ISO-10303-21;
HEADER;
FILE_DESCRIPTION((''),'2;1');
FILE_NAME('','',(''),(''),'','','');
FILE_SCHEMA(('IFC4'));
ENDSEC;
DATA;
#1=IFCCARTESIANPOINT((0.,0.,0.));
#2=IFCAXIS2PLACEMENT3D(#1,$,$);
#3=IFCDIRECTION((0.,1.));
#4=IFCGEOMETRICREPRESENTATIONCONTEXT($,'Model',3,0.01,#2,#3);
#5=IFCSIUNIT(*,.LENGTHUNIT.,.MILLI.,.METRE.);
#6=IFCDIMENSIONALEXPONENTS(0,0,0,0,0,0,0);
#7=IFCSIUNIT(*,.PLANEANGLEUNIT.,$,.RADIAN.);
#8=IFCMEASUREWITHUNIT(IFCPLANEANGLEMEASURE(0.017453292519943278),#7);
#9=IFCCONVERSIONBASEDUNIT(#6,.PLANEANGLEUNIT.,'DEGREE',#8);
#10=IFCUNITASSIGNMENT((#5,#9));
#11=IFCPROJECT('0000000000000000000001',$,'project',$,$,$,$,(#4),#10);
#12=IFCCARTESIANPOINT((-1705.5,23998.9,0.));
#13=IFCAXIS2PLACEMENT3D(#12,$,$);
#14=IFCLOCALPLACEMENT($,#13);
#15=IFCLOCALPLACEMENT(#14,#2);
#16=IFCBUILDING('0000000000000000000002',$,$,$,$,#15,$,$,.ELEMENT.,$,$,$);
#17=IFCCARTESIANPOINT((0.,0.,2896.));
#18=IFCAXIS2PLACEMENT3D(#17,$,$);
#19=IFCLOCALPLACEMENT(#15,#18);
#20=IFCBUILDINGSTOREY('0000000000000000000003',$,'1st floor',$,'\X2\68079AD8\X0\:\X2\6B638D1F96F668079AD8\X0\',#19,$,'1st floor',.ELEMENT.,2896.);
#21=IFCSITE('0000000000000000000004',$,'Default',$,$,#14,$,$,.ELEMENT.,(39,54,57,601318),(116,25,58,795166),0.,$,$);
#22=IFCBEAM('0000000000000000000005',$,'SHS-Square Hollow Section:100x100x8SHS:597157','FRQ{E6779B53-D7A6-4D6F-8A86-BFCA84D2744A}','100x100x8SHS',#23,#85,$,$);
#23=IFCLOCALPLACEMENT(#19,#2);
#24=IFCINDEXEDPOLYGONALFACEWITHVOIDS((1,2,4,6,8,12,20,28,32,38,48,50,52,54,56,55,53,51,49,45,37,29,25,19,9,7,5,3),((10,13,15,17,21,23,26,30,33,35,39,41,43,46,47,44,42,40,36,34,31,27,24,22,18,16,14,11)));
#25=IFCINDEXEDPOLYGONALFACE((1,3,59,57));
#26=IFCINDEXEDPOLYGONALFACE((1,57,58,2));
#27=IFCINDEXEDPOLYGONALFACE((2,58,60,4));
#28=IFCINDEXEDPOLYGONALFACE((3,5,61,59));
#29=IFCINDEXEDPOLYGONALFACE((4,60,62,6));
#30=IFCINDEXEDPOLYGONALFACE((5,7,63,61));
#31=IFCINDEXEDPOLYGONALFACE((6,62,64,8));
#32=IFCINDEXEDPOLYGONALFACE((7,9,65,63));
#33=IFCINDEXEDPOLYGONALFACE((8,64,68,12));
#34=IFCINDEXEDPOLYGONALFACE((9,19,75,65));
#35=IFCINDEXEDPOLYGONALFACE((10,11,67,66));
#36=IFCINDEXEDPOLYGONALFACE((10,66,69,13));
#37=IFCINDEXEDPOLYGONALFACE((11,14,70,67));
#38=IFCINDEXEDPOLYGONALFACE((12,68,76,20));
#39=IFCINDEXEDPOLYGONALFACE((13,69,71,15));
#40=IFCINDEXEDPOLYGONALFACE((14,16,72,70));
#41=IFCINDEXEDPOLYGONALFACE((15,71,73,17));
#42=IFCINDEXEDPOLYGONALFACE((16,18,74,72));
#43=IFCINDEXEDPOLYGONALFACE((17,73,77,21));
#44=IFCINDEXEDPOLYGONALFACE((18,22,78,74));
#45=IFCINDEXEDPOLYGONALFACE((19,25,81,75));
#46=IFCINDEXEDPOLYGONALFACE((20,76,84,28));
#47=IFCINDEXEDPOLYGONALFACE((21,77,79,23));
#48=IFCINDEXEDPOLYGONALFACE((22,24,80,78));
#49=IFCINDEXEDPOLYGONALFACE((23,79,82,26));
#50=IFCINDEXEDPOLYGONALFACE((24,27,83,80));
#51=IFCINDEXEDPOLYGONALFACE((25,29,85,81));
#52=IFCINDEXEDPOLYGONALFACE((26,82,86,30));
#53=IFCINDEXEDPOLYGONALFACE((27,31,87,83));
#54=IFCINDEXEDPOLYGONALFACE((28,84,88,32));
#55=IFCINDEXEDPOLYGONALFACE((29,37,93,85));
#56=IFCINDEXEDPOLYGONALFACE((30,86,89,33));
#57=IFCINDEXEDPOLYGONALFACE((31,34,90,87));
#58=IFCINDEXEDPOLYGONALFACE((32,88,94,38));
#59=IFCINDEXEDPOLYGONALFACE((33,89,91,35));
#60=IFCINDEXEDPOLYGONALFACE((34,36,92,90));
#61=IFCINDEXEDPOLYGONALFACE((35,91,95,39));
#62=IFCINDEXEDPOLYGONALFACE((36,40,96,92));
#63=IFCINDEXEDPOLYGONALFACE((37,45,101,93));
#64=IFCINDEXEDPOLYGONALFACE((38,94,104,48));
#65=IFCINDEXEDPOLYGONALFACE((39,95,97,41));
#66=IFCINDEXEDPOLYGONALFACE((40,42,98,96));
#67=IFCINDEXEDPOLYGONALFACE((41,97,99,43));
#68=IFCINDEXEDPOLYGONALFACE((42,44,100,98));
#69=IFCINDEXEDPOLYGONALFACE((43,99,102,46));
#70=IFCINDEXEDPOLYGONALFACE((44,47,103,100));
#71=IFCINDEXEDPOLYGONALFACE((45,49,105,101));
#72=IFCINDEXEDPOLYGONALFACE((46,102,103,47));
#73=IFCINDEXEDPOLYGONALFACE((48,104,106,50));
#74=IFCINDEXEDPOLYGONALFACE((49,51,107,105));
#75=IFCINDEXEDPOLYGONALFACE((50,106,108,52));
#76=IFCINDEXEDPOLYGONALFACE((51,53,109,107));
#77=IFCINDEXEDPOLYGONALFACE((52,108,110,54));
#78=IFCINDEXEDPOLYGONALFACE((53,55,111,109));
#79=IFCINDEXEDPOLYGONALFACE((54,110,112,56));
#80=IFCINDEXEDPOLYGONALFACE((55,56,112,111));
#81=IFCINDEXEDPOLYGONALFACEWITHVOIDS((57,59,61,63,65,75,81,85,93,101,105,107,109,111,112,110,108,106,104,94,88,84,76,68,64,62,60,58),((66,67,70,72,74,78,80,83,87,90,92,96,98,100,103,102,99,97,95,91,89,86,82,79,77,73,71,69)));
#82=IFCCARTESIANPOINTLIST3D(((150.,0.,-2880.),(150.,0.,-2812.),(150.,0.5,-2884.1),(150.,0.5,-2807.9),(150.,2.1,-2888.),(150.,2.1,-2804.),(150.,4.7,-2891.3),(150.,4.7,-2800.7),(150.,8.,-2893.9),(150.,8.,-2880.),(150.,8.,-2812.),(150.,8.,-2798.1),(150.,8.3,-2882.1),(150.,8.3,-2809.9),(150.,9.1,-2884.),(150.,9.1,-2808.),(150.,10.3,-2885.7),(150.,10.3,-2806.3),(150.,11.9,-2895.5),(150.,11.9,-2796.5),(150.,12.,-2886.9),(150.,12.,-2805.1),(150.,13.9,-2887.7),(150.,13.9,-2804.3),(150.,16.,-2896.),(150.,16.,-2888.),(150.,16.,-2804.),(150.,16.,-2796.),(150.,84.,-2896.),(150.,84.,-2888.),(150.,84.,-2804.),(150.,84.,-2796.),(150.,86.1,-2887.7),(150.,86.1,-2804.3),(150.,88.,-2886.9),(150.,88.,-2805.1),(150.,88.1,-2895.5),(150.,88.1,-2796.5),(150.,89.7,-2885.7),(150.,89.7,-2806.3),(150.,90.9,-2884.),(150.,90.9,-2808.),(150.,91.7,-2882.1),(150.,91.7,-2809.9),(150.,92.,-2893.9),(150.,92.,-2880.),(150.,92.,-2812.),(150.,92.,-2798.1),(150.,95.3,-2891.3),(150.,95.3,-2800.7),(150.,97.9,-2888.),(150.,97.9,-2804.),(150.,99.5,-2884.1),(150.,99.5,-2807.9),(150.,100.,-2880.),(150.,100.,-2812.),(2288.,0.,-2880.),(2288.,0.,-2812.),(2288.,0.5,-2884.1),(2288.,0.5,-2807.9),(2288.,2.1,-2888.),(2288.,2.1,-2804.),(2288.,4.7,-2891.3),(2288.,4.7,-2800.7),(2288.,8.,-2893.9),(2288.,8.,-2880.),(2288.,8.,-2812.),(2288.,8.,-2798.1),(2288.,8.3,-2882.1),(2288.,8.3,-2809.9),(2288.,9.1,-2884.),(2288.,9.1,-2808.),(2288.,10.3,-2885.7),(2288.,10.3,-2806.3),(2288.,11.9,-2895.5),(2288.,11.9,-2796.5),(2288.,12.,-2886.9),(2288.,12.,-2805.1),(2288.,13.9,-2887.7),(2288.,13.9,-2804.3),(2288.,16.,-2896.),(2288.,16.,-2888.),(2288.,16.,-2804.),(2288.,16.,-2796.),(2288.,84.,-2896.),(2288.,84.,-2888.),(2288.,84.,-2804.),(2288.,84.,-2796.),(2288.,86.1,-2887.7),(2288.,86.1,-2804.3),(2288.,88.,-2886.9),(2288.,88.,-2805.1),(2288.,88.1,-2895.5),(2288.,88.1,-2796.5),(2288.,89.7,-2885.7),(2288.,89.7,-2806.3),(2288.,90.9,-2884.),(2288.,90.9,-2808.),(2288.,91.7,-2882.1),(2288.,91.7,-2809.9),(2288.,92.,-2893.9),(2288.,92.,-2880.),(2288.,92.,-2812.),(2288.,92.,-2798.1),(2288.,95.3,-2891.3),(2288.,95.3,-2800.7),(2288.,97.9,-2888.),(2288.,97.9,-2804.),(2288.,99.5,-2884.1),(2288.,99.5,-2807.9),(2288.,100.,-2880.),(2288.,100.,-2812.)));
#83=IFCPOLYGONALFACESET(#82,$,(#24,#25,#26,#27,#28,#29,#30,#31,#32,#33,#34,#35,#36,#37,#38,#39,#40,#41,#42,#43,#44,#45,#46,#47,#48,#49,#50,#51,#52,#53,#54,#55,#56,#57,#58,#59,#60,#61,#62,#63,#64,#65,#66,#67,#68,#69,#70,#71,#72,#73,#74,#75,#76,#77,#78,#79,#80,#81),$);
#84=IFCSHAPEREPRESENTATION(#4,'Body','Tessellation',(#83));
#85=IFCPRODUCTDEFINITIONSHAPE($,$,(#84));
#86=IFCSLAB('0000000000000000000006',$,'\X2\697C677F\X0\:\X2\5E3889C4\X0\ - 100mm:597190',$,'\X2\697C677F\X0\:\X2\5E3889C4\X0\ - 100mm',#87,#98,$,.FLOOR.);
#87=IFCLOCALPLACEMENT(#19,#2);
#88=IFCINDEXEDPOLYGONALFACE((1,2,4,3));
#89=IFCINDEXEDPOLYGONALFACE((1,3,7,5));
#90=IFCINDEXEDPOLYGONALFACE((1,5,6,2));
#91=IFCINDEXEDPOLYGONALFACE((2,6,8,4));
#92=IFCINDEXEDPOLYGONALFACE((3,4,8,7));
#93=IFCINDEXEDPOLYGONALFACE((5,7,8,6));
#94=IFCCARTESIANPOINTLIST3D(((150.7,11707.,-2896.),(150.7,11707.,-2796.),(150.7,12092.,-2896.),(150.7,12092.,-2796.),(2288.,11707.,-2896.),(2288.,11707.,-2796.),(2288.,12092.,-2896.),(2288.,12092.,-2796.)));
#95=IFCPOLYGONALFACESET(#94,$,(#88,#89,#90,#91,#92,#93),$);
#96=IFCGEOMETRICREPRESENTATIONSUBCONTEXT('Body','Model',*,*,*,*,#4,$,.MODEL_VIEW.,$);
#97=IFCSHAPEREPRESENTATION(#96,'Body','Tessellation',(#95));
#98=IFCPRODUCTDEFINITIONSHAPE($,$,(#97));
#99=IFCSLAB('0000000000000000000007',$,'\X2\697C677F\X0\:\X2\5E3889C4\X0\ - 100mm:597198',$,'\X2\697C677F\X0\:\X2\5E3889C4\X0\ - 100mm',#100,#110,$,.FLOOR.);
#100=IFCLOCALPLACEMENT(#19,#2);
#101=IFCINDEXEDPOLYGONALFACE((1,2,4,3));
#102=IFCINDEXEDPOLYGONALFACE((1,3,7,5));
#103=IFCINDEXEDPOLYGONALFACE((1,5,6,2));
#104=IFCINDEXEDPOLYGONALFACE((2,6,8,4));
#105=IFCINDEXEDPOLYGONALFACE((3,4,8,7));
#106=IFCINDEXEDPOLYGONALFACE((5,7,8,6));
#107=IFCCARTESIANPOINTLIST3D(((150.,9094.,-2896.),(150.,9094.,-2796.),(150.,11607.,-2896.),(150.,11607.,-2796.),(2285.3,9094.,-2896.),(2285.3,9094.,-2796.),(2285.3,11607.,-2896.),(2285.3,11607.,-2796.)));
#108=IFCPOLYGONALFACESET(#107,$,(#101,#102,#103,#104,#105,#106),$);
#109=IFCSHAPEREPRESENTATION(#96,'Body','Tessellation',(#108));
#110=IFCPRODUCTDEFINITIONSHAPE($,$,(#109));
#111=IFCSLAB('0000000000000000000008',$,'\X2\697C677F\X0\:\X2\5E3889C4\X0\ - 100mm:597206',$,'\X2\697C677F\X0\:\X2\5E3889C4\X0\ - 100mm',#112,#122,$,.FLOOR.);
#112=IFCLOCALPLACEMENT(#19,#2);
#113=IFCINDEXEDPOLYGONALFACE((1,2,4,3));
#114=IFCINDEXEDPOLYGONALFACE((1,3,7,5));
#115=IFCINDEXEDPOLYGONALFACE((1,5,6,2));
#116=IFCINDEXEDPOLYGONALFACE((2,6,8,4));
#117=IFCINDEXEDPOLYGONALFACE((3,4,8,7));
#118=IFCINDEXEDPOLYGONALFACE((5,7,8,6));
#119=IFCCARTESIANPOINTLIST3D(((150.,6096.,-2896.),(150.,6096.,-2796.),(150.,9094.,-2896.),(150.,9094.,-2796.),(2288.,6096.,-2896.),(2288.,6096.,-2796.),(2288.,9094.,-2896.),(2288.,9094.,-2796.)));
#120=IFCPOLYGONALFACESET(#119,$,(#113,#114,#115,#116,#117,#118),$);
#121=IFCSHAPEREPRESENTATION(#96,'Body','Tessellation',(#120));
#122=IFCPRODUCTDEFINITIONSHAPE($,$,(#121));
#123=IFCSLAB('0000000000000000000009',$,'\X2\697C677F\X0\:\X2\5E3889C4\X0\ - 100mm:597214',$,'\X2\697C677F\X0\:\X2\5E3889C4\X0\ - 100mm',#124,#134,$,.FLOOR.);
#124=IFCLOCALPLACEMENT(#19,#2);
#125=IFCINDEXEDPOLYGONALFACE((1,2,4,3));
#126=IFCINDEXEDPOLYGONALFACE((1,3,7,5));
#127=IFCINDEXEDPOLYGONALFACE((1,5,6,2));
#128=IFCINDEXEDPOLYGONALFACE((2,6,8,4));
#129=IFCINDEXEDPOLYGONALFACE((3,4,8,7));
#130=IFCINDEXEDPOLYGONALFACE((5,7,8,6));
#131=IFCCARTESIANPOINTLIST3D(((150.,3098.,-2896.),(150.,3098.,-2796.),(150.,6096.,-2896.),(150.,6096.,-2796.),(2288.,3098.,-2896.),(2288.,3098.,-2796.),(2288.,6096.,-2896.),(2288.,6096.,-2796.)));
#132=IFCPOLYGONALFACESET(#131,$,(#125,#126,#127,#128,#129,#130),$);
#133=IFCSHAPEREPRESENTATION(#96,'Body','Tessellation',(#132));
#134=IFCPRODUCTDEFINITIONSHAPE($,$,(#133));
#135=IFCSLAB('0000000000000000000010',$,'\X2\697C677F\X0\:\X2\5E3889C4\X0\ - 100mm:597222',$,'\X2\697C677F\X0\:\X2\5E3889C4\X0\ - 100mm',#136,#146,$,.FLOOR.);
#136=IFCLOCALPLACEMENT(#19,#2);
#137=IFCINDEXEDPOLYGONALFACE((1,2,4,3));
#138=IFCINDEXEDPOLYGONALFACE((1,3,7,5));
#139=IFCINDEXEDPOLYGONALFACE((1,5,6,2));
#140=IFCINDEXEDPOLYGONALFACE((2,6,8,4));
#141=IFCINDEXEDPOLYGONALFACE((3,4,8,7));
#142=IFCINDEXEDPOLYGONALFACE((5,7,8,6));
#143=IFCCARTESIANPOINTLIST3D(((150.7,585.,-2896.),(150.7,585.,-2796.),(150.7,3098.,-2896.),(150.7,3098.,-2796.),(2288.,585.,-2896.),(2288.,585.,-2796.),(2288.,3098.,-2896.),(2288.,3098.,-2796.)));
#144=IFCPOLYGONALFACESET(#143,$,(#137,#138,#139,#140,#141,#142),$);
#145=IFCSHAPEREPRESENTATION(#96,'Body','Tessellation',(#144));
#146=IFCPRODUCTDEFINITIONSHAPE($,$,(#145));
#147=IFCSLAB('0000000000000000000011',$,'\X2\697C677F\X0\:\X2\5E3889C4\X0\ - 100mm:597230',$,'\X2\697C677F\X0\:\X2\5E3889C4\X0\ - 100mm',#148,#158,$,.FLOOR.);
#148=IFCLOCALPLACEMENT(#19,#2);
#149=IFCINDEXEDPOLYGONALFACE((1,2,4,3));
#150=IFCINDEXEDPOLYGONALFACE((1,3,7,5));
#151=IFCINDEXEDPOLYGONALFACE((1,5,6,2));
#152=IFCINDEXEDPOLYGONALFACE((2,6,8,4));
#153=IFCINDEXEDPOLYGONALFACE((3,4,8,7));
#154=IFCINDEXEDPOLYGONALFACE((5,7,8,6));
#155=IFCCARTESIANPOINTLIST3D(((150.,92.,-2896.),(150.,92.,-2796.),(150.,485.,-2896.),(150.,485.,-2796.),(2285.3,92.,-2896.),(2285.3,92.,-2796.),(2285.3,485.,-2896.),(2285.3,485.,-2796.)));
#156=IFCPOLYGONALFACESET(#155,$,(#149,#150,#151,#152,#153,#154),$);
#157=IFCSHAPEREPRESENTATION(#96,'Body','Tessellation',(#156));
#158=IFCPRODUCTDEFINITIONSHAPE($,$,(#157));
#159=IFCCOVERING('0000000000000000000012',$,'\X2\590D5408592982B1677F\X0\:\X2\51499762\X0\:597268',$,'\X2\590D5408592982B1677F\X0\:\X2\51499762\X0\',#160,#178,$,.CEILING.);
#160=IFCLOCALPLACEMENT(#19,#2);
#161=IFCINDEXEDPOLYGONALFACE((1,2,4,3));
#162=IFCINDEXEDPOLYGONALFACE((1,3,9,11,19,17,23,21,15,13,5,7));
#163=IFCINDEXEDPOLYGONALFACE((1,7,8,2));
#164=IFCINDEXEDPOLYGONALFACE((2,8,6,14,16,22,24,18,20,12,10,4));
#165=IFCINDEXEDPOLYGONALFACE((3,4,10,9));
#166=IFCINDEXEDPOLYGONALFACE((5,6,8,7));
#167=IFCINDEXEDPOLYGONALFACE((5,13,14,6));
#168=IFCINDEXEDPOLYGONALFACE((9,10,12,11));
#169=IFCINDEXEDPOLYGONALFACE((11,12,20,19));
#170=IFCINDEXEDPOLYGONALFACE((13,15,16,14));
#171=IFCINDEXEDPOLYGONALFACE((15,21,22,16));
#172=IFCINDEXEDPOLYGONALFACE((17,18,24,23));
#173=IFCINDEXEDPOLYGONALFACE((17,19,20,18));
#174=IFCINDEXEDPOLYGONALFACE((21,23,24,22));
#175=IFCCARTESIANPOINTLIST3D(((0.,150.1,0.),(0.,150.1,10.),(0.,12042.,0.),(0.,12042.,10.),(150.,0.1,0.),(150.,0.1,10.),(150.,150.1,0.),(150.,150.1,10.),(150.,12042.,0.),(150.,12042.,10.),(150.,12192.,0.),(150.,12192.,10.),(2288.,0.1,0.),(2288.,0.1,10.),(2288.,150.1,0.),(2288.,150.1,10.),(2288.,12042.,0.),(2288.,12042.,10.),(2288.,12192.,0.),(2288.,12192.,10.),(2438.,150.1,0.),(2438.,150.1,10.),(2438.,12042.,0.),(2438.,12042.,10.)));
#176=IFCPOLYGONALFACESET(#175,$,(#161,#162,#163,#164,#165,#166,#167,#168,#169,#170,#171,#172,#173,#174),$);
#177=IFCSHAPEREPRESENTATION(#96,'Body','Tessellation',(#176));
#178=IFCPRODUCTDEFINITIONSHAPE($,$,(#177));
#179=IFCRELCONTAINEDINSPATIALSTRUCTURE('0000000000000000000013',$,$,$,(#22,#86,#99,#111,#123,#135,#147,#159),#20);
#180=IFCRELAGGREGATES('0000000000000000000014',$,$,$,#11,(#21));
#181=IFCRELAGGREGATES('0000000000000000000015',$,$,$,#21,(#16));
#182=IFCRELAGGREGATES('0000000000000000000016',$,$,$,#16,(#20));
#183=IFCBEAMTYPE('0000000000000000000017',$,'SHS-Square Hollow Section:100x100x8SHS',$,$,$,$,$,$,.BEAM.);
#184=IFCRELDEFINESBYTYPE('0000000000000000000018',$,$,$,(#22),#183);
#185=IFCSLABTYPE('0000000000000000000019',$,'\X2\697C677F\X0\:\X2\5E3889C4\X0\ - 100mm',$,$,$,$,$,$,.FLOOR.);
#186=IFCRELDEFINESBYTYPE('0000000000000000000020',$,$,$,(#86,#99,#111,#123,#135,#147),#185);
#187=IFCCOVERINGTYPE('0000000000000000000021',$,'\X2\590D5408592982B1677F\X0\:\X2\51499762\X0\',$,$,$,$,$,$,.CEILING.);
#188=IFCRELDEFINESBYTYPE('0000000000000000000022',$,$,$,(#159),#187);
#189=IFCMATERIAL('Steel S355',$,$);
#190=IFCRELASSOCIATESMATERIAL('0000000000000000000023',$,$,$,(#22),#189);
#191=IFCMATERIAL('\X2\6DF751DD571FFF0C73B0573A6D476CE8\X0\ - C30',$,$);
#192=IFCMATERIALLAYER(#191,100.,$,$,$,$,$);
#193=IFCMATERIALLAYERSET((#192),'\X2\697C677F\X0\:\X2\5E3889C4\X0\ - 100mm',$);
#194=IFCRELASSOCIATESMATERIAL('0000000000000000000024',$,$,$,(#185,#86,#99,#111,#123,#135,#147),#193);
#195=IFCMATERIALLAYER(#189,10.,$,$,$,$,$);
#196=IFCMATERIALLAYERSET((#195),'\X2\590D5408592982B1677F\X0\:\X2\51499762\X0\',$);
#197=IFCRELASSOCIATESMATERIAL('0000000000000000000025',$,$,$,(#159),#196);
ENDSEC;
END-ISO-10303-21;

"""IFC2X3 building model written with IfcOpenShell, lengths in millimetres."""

from ifc_helpers import new_model, entity, si_unit, converted_unit, direction, frame, frame_2d, origin, origin_2d, origin_2d_with_axis, place, context, subcontext, project, spatial, polyline, rectangle, hollow_rectangle, outline, extrude, clip, halfspace, material, layer, layer_set, layer_usage, type_object, element, save


model = new_model("IFC2X3")

# Units and contexts
model_context = context("Model", 3, precision=0.01, world=origin(), true_north=direction((0.0, 1.0)))
body_context = subcontext(model_context, "Body", "Model", "MODEL_VIEW")
ifc_project = project(units=[si_unit("LENGTHUNIT", "METRE", prefix="MILLI"), converted_unit("PLANEANGLEUNIT", "DEGREE", entity("IfcPlaneAngleMeasure", 0.017453292519943278), si_unit("PLANEANGLEUNIT", "RADIAN"), dimensions=[0, 0, 0, 0, 0, 0, 0])], contexts=[model_context])

# Site, building, storey
site_placement = place(None, frame((-1705.5, 23998.9, 0.0)))
site = spatial("IfcSite", under=ifc_project, at=site_placement, Name="Default", CompositionType="ELEMENT", RefLatitude=(39, 54, 57, 601318), RefLongitude=(116, 25, 58, 795166), RefElevation=0.0)
building_placement = place(site_placement, origin())
building = spatial("IfcBuilding", under=site, at=building_placement, CompositionType="ELEMENT")
storey_placement = place(building_placement, frame((0.0, 0.0, 2896.0)))
storey = spatial("IfcBuildingStorey", under=building, at=storey_placement, Name="1st floor", ObjectType="标高:正负零标高", LongName="1st floor", CompositionType="ELEMENT", Elevation=2896.0)

# Shared definitions
ifc_material_1 = material(Name="Steel S355")

# Beam
beam_type_1 = type_object("IfcBeamType", Name="SHS-Square Hollow Section:100x100x8SHS", PredefinedType="BEAM")
beam_1_placement = place(storey_placement, frame((-57.7, 50.0, -2846.0), z_axis=(-1.0, 0.0, 0.0), x_axis=(0.0, -1.0, 0.0)))
element("IfcBeam", 1, at=beam_1_placement, inside=storey, type_object=beam_type_1, material=ifc_material_1, Name="SHS-Square Hollow Section:100x100x8SHS:597157", Description="FRQ{E6779B53-D7A6-4D6F-8A86-BFCA84D2744A}", ObjectType="100x100x8SHS", context=model_context, shape_type="Clipping", body=[
    clip(clip(extrude(hollow_rectangle(XDim=100.0, YDim=100.0, WallThickness=8.0, InnerFilletRadius=8.0, OuterFilletRadius=16.0, at=origin_2d()), origin(), (0.0, 0.0, -1.0), 2551.4), halfspace(frame((50.0, -50.0, -2345.7), z_axis=(0.0, 0.0, 1.0), x_axis=(1.0, 0.0, 0.0)), True)), halfspace(frame((50.0, -50.0, -207.7), z_axis=(0.0, 0.0, -1.0), x_axis=(-1.0, 0.0, 0.0)), True)),
])

# Slabs
ifc_material_2 = material(Name="混凝土，现场浇注 - C30")
ifc_layer_1 = layer(ifc_material_2, 100.0)
ifc_layer_set_1 = layer_set([ifc_layer_1], Name="楼板:常规 - 100mm")
ifc_layer_usage_1 = layer_usage(ifc_layer_set_1, "AXIS3", "POSITIVE", 0.0)
slab_type = type_object("IfcSlabType", Name="楼板:常规 - 100mm", PredefinedType="FLOOR", material=ifc_layer_set_1)
slab_1_placement = place(storey_placement, origin())
element("IfcSlab", 2, at=slab_1_placement, inside=storey, type_object=slab_type, material=ifc_layer_usage_1, Name="楼板:常规 - 100mm:597190", ObjectType="楼板:常规 - 100mm", PredefinedType="FLOOR", context=body_context, shape_type="SweptSolid", body=[
    extrude(rectangle(XDim=385.0, YDim=2137.3, at=origin_2d_with_axis()), frame((1219.3, 11899.5, -2796.0), z_axis=(0.0, 0.0, -1.0), x_axis=(0.0, 1.0, 0.0)), (0.0, 0.0, 1.0), 100.0),
])
ifc_layer_usage_2 = layer_usage(ifc_layer_set_1, "AXIS3", "POSITIVE", 0.0)
slab_2_placement = place(storey_placement, origin())
element("IfcSlab", 3, at=slab_2_placement, inside=storey, type_object=slab_type, material=ifc_layer_usage_2, Name="楼板:常规 - 100mm:597198", ObjectType="楼板:常规 - 100mm", PredefinedType="FLOOR", context=body_context, shape_type="SweptSolid", body=[
    extrude(rectangle(XDim=2513.0, YDim=2135.3, at=frame_2d((0.0, 0.0), x_axis=(1.0, 0.0))), frame((1217.6, 10350.5, -2796.0), z_axis=(0.0, 0.0, -1.0), x_axis=(0.0, 1.0, 0.0)), (0.0, 0.0, 1.0), 100.0),
])
ifc_layer_usage_3 = layer_usage(ifc_layer_set_1, "AXIS3", "POSITIVE", 0.0)
slab_3_placement = place(storey_placement, origin())
element("IfcSlab", 4, at=slab_3_placement, inside=storey, type_object=slab_type, material=ifc_layer_usage_3, Name="楼板:常规 - 100mm:597206", ObjectType="楼板:常规 - 100mm", PredefinedType="FLOOR", context=body_context, shape_type="SweptSolid", body=[
    extrude(rectangle(XDim=2998.0, YDim=2138.0, at=origin_2d_with_axis()), frame((1219.0, 7595.0, -2796.0), z_axis=(0.0, 0.0, -1.0), x_axis=(0.0, 1.0, 0.0)), (0.0, 0.0, 1.0), 100.0),
])
ifc_layer_usage_4 = layer_usage(ifc_layer_set_1, "AXIS3", "POSITIVE", 0.0)
slab_4_placement = place(storey_placement, origin())
element("IfcSlab", 5, at=slab_4_placement, inside=storey, type_object=slab_type, material=ifc_layer_usage_4, Name="楼板:常规 - 100mm:597214", ObjectType="楼板:常规 - 100mm", PredefinedType="FLOOR", context=body_context, shape_type="SweptSolid", body=[
    extrude(rectangle(XDim=2998.0, YDim=2138.0, at=frame_2d((0.0, 0.0), x_axis=(1.0, 0.0))), frame((1219.0, 4597.0, -2796.0), z_axis=(0.0, 0.0, -1.0), x_axis=(0.0, 1.0, 0.0)), (0.0, 0.0, 1.0), 100.0),
])
ifc_layer_usage_5 = layer_usage(ifc_layer_set_1, "AXIS3", "POSITIVE", 0.0)
slab_5_placement = place(storey_placement, origin())
element("IfcSlab", 6, at=slab_5_placement, inside=storey, type_object=slab_type, material=ifc_layer_usage_5, Name="楼板:常规 - 100mm:597222", ObjectType="楼板:常规 - 100mm", PredefinedType="FLOOR", context=body_context, shape_type="SweptSolid", body=[
    extrude(rectangle(XDim=2513.0, YDim=2137.3, at=origin_2d_with_axis()), frame((1219.3, 1841.5, -2796.0), z_axis=(0.0, 0.0, -1.0), x_axis=(0.0, 1.0, 0.0)), (0.0, 0.0, 1.0), 100.0),
])
ifc_layer_usage_6 = layer_usage(ifc_layer_set_1, "AXIS3", "POSITIVE", 0.0)
slab_6_placement = place(storey_placement, origin())
element("IfcSlab", 7, at=slab_6_placement, inside=storey, type_object=slab_type, material=ifc_layer_usage_6, Name="楼板:常规 - 100mm:597230", ObjectType="楼板:常规 - 100mm", PredefinedType="FLOOR", context=body_context, shape_type="SweptSolid", body=[
    extrude(rectangle(XDim=393.0, YDim=2135.3, at=frame_2d((0.0, 0.0), x_axis=(1.0, 0.0))), frame((1217.7, 288.5, -2796.0), z_axis=(0.0, 0.0, -1.0), x_axis=(0.0, 1.0, 0.0)), (0.0, 0.0, 1.0), 100.0),
])

# Covering
ifc_layer_2 = layer(ifc_material_1, 10.0)
ifc_layer_set_2 = layer_set([ifc_layer_2], Name="复合天花板:光面")
ifc_layer_usage_7 = layer_usage(ifc_layer_set_2, "AXIS3", "NEGATIVE", 10.0)
covering_type = type_object("IfcCoveringType", Name="复合天花板:光面", PredefinedType="CEILING")
covering_placement = place(storey_placement, origin())
element("IfcCovering", 8, at=covering_placement, inside=storey, type_object=covering_type, material=ifc_layer_usage_7, Name="复合天花板:光面:597268", ObjectType="复合天花板:光面", PredefinedType="CEILING", context=body_context, shape_type="SweptSolid", body=[
    extrude(outline(polyline([(5946.0, -1069.0), (6096.0, -1069.0), (6096.0, 1069.0), (5945.9, 1069.0), (5945.9, 1219.0), (-5946.0, 1219.0), (-5946.0, 1069.0), (-6096.0, 1069.0), (-6096.0, -1069.0), (-5946.0, -1069.0), (-5946.0, -1219.0), (5946.0, -1219.0), (5946.0, -1069.0)])), frame((1219.0, 6096.0, 0.0), z_axis=(0.0, 0.0, 1.0), x_axis=(0.0, 1.0, 0.0)), (0.0, 0.0, 1.0), 10.0),
])

save(model, "model.ifc")
